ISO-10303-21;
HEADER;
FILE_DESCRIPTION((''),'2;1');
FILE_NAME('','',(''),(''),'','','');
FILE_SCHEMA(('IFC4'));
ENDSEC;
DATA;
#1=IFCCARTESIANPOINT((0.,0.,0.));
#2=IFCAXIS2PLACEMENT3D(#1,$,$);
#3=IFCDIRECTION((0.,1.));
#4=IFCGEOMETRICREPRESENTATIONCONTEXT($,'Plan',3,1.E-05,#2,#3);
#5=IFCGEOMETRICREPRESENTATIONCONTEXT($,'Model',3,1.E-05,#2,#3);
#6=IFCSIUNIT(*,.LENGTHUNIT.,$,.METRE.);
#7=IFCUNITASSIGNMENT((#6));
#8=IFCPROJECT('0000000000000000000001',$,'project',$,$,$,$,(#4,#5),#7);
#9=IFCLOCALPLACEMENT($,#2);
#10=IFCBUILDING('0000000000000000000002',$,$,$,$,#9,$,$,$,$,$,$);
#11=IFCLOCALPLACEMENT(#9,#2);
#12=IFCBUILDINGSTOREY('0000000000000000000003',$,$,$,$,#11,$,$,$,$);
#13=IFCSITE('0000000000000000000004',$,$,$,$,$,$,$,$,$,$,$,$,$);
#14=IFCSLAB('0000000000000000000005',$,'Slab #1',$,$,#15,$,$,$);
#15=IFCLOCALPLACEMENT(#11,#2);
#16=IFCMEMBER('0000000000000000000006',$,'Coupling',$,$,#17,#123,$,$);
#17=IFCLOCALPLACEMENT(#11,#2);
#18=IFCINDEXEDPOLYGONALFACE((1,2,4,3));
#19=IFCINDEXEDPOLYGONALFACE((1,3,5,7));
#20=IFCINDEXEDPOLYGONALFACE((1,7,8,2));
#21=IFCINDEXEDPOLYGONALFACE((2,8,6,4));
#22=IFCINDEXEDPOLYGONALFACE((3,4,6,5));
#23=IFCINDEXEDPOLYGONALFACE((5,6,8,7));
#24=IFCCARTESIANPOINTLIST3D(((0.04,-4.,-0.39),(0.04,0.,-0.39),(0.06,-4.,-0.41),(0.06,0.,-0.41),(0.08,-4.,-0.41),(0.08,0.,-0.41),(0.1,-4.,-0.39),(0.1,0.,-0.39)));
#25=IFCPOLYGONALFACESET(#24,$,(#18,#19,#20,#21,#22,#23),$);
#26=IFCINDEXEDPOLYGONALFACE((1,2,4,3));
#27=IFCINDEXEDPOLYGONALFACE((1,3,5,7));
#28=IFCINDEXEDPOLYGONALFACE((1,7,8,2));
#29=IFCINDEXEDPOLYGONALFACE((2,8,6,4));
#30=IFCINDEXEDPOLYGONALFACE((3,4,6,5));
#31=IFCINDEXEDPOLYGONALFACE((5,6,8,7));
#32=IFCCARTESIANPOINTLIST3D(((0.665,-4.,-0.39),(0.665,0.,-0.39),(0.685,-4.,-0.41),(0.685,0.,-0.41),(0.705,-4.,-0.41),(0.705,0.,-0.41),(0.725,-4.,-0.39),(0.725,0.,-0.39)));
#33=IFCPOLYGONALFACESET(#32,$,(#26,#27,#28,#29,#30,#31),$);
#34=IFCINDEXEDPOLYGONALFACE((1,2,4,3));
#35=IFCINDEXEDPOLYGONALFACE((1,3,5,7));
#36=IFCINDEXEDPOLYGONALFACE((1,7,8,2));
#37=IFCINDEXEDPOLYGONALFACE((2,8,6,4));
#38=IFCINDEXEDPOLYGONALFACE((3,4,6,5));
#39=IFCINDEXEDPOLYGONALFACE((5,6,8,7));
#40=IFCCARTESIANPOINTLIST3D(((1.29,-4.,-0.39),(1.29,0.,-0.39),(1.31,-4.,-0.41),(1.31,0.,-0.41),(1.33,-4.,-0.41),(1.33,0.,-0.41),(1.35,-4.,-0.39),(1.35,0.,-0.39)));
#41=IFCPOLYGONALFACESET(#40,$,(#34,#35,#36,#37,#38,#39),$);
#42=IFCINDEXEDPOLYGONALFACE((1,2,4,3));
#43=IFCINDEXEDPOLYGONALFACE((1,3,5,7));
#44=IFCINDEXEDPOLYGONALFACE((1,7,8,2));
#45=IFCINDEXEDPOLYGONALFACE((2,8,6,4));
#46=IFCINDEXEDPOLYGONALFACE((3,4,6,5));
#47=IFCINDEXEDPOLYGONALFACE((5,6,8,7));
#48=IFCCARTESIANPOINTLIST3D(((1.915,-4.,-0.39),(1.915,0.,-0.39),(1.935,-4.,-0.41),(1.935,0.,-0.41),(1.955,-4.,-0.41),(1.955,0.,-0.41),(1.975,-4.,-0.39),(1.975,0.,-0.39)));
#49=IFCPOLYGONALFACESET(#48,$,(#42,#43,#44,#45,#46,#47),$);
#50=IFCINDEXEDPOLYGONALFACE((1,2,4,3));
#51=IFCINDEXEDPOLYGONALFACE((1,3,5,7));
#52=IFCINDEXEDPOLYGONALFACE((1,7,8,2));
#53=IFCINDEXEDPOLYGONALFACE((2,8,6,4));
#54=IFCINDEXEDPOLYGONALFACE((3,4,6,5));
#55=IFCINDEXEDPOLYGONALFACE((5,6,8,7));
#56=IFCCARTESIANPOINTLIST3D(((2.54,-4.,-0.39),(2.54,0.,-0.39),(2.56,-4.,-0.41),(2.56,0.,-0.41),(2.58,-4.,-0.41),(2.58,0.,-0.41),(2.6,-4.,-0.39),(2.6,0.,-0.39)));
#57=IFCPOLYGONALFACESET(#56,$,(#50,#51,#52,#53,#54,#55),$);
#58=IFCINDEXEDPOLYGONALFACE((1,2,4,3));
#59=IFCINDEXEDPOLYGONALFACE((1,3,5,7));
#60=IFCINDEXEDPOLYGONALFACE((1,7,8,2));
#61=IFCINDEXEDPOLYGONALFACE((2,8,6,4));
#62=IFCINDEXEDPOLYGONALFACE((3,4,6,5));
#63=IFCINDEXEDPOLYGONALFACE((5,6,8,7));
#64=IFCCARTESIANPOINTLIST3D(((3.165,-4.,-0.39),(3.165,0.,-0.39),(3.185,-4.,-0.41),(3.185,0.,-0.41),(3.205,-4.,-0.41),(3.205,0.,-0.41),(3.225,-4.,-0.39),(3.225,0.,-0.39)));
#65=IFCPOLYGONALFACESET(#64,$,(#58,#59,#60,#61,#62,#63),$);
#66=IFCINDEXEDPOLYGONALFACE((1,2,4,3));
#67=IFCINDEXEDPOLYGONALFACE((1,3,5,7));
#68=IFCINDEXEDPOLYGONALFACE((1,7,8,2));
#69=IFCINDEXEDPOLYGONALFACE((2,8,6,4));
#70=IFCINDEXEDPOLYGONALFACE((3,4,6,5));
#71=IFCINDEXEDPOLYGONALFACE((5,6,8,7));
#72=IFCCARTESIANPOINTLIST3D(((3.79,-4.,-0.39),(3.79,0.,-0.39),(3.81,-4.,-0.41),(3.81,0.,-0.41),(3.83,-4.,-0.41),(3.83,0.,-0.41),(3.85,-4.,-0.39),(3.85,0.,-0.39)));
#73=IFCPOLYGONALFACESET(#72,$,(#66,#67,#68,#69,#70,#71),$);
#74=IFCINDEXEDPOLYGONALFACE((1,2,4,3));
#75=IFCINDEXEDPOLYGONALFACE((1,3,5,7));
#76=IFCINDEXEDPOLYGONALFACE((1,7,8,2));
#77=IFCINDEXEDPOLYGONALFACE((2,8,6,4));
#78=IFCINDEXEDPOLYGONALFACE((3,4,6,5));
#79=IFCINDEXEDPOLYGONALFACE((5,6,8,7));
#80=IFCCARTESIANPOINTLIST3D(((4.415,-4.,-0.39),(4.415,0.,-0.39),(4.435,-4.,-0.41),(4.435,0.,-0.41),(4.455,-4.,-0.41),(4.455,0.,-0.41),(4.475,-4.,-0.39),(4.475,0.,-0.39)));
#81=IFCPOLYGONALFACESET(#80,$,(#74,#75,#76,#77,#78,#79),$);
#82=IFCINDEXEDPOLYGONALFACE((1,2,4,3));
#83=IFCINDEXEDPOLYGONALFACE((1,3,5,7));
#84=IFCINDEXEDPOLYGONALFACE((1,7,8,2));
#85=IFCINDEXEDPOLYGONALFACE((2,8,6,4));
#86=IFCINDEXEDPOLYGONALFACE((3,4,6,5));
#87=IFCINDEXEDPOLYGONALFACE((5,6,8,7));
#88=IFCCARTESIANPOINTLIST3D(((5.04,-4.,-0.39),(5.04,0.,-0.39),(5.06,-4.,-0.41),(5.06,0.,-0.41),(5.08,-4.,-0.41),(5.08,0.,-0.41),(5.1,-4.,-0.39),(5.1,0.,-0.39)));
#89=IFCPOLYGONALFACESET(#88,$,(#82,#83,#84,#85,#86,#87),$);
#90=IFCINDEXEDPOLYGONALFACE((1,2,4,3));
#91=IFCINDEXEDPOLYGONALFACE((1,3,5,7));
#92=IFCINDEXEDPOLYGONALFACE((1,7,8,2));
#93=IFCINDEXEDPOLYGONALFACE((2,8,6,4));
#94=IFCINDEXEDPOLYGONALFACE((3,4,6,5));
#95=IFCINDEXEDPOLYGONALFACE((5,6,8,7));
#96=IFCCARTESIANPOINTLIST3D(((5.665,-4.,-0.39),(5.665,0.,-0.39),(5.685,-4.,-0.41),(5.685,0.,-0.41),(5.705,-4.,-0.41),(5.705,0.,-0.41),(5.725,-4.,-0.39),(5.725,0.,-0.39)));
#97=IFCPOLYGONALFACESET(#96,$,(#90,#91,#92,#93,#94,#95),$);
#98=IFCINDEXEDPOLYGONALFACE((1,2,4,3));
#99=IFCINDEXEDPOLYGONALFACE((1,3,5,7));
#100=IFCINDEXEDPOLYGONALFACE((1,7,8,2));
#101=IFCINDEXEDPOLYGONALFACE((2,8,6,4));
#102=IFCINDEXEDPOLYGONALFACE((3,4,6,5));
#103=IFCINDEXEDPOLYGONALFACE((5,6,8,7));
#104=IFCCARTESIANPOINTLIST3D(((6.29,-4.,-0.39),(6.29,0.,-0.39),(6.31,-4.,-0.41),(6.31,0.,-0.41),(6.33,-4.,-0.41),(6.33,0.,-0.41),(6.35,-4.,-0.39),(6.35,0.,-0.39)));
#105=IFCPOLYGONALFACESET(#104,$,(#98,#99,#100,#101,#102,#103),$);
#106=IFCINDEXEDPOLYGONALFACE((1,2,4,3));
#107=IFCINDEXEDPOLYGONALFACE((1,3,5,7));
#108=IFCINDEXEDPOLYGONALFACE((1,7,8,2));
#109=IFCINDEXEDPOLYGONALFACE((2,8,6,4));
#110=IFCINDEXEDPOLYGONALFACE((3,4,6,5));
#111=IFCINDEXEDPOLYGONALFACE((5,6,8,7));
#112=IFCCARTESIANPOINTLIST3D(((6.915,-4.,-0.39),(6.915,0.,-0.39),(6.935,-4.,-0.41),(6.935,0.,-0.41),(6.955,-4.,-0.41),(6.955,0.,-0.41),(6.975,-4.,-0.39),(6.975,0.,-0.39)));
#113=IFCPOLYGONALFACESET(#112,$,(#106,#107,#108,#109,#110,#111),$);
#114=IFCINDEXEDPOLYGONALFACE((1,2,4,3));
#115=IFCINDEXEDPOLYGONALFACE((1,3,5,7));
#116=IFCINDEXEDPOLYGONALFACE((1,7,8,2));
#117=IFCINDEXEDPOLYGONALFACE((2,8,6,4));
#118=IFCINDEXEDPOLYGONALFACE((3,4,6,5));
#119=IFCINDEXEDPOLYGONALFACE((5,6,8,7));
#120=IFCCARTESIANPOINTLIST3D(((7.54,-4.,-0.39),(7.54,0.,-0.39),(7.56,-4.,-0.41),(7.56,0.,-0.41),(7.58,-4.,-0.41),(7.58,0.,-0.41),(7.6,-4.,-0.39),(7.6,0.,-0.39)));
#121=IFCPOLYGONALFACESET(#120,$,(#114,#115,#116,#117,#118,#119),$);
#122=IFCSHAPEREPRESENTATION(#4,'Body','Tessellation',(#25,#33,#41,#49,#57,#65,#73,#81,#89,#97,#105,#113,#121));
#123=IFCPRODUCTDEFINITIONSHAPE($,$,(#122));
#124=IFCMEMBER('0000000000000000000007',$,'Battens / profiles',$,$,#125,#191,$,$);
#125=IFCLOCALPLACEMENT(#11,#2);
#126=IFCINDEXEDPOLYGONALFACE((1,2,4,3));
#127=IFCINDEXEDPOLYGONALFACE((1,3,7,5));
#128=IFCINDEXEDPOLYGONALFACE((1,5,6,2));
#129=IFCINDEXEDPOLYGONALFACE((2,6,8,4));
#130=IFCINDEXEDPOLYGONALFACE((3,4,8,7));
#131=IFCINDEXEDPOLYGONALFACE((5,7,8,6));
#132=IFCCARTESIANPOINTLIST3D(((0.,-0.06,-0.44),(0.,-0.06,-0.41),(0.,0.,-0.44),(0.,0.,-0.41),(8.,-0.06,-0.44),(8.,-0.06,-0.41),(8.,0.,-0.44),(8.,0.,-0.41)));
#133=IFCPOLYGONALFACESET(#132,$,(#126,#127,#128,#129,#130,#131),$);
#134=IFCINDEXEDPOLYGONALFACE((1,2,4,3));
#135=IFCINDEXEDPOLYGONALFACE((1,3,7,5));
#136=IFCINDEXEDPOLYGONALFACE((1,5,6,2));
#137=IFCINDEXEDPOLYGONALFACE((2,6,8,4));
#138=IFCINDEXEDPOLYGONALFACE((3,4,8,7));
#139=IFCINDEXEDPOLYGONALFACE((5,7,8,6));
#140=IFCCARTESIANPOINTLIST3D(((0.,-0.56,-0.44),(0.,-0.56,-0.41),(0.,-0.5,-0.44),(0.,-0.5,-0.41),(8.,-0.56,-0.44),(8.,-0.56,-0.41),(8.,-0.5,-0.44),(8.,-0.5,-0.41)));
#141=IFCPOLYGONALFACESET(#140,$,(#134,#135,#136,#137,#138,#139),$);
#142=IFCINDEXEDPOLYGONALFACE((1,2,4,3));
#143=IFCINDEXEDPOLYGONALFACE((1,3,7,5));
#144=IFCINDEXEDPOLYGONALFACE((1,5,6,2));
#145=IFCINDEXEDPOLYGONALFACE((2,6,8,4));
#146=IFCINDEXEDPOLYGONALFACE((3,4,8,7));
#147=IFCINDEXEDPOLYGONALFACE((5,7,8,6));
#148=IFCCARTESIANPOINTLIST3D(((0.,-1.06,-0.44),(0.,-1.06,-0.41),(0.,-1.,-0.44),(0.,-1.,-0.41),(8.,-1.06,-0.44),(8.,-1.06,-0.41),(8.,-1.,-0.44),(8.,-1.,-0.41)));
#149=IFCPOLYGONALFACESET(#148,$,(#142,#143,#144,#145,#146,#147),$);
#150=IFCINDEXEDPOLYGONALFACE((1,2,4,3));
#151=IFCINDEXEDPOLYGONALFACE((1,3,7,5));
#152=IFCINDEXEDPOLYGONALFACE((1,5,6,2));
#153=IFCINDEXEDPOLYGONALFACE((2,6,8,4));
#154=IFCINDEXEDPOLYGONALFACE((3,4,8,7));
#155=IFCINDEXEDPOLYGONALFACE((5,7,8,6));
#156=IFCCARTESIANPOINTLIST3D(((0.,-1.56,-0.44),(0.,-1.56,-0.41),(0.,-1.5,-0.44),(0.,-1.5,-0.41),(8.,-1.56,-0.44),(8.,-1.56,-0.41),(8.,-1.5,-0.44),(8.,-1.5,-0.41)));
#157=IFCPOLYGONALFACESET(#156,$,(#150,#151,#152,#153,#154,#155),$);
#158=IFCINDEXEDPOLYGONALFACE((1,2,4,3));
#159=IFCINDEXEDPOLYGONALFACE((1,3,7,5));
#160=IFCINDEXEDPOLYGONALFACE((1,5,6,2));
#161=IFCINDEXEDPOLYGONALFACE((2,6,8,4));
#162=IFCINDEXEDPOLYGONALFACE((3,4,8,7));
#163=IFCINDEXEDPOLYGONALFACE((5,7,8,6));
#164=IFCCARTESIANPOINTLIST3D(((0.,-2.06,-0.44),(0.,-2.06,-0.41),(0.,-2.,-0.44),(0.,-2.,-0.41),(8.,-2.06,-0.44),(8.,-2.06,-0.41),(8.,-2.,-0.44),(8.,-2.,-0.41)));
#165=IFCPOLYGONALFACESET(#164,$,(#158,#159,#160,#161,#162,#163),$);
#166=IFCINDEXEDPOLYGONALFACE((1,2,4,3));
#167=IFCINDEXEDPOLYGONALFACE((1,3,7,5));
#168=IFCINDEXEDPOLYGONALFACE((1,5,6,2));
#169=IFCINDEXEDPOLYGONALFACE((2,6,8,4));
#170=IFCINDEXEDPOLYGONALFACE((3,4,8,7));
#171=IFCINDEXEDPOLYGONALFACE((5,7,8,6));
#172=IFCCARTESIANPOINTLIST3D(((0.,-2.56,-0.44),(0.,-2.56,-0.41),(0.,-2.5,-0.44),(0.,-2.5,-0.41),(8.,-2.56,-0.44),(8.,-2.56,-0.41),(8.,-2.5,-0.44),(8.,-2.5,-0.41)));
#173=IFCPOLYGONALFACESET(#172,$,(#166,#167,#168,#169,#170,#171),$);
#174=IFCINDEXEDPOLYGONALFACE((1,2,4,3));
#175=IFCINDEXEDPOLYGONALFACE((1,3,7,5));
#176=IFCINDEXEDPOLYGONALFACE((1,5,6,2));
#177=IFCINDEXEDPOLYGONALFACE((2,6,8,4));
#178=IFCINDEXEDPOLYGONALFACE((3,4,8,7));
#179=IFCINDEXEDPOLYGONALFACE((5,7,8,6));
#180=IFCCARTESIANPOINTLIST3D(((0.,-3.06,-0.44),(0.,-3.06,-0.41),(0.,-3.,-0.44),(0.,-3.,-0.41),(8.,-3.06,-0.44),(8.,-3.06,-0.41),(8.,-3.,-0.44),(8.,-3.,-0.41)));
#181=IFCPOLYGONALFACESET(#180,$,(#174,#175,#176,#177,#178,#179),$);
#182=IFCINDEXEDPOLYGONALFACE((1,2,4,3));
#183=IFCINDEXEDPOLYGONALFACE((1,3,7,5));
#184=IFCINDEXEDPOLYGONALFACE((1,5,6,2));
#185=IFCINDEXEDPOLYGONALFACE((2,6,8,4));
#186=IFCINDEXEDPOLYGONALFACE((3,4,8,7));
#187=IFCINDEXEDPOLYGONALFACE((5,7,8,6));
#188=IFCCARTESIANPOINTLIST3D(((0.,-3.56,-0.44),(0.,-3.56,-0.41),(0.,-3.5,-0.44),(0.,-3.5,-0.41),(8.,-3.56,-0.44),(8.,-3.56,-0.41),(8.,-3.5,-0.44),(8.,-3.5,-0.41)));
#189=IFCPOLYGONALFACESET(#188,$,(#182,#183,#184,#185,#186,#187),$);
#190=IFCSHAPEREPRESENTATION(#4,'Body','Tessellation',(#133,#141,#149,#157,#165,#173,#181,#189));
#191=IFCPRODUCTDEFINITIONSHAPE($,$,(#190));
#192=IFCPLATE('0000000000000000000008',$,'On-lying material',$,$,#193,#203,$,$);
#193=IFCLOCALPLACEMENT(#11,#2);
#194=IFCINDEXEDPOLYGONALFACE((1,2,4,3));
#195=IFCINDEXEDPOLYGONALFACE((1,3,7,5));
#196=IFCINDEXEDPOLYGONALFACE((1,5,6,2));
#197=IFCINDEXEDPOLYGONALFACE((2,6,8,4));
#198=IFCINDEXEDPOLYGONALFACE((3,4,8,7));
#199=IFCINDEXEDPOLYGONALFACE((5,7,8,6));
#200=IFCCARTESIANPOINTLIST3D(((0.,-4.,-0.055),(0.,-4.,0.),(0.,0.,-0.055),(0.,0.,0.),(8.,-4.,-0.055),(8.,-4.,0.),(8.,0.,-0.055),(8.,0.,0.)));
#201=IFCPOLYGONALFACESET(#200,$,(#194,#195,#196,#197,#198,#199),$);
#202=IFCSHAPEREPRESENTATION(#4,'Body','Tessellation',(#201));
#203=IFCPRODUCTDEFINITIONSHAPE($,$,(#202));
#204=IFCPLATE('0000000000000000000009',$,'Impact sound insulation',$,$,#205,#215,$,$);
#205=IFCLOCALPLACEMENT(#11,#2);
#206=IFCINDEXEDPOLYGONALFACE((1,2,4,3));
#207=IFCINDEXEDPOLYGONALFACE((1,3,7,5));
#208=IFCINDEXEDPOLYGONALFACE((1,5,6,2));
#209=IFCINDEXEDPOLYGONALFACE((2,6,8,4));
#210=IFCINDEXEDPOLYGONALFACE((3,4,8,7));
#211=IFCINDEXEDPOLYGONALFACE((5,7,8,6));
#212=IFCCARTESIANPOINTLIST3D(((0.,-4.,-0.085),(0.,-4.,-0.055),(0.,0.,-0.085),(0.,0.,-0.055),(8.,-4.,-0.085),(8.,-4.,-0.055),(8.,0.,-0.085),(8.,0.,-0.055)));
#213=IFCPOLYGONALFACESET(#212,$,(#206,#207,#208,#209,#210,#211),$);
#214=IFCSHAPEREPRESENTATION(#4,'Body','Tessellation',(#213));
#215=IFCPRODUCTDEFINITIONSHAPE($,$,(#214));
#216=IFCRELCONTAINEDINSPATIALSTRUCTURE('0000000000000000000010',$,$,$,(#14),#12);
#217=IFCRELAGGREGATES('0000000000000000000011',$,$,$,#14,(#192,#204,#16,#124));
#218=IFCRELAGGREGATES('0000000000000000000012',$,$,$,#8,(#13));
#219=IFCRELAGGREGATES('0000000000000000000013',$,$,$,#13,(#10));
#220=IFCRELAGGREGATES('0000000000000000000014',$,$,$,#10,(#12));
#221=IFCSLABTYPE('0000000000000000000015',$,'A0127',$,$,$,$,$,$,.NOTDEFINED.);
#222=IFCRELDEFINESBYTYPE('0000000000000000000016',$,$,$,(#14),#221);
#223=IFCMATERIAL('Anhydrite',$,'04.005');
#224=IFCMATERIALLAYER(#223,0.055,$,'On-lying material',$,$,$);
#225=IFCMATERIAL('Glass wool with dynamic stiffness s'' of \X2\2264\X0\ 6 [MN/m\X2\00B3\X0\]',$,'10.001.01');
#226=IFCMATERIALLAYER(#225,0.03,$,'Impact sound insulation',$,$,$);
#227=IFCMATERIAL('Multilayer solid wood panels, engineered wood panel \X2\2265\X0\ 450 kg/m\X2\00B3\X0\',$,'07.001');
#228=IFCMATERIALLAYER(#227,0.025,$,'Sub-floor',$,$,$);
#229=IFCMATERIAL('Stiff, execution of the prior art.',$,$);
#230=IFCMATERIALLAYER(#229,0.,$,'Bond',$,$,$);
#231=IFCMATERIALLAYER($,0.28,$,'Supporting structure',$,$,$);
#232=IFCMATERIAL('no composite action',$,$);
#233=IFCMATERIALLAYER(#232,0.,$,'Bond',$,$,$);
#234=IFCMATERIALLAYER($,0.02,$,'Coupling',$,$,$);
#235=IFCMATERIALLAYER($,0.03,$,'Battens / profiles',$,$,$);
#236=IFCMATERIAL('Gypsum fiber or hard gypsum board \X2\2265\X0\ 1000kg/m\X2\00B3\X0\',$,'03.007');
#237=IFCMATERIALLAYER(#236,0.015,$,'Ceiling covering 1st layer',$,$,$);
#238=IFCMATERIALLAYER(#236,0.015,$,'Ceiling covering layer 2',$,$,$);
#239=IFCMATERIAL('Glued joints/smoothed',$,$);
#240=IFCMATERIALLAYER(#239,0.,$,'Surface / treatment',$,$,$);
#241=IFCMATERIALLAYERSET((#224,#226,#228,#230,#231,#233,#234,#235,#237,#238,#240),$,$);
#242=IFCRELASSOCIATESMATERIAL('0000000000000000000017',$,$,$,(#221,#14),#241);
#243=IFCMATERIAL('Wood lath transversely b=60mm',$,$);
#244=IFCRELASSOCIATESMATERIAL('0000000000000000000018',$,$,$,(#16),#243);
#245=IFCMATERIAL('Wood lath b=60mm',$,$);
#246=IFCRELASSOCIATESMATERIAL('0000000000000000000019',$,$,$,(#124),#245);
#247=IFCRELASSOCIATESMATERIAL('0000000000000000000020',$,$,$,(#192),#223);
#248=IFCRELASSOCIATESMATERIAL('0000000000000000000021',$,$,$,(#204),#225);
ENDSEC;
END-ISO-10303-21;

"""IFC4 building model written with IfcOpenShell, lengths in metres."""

from ifc_helpers import new_model, si_unit, direction, frame, frame_2d, origin, origin_with_axes, place, context, project, spatial, polyline, rectangle, outline, extrude, material, layer, layer_set, type_object, element, aggregate, save


model = new_model("IFC4")

# Units and contexts
plan_context = context("Plan", 3, precision=1e-05, world=origin(), true_north=direction((0.0, 1.0)))
model_context = context("Model", 3, precision=1e-05, world=origin(), true_north=direction((0.0, 1.0)))
ifc_project = project(units=[si_unit("LENGTHUNIT", "METRE")], contexts=[plan_context, model_context])

# Site, building, storey
site = spatial("IfcSite", under=ifc_project)
building_placement = place(None, origin())
building = spatial("IfcBuilding", under=site, at=building_placement)
storey_placement = place(building_placement, origin())
storey = spatial("IfcBuildingStorey", under=building, at=storey_placement)

# Slab, members, plates
ifc_material_1 = material(Name="Anhydrite", Category="04.005")
ifc_layer_1 = layer(ifc_material_1, 0.055, Name="On-lying material")
ifc_material_2 = material(Name="Glass wool with dynamic stiffness s' of ≤ 6 [MN/m³]", Category="10.001.01")
ifc_layer_2 = layer(ifc_material_2, 0.03, Name="Impact sound insulation")
ifc_material_3 = material(Name="Multilayer solid wood panels, engineered wood panel ≥ 450 kg/m³", Category="07.001")
ifc_layer_3 = layer(ifc_material_3, 0.025, Name="Sub-floor")
ifc_material_4 = material(Name="Stiff, execution of the prior art.")
ifc_layer_4 = layer(ifc_material_4, 0.0, Name="Bond")
ifc_layer_5 = layer(None, 0.28, Name="Supporting structure")
ifc_material_5 = material(Name="no composite action")
ifc_layer_6 = layer(ifc_material_5, 0.0, Name="Bond")
ifc_layer_7 = layer(None, 0.02, Name="Coupling")
ifc_layer_8 = layer(None, 0.03, Name="Battens / profiles")
ifc_material_6 = material(Name="Gypsum fiber or hard gypsum board ≥ 1000kg/m³", Category="03.007")
ifc_layer_9 = layer(ifc_material_6, 0.015, Name="Ceiling covering 1st layer")
ifc_layer_10 = layer(ifc_material_6, 0.015, Name="Ceiling covering layer 2")
ifc_material_7 = material(Name="Glued joints/smoothed")
ifc_layer_11 = layer(ifc_material_7, 0.0, Name="Surface / treatment")
ifc_layer_set = layer_set([ifc_layer_1, ifc_layer_2, ifc_layer_3, ifc_layer_4, ifc_layer_5, ifc_layer_6, ifc_layer_7, ifc_layer_8, ifc_layer_9, ifc_layer_10, ifc_layer_11])
slab_type = type_object("IfcSlabType", Name="A0127", PredefinedType="NOTDEFINED", material=ifc_layer_set)
slab_placement = place(None, frame((0.0, 0.0, 0.0), z_axis=(0.0, 0.0, -1.0), x_axis=(1.0, 0.0, 0.0)))
slab = element("IfcSlab", 1, at=slab_placement, inside=storey, type_object=slab_type, material=ifc_layer_set, Name="Slab #1")
ifc_material_8 = material(Name="Wood lath transversely b=60mm")
member_1_placement = place(slab_placement, origin())
member_1 = element("IfcMember", 2, at=member_1_placement, material=ifc_material_8, Name="Coupling", context=plan_context, shape_type="SweptSolid", body=[
    extrude(outline(polyline([(0.0, 0.0), (0.06, 0.0), (0.04, 0.02), (0.02, 0.02), (0.0, 0.0)])), frame((0.04, 4.0, 0.39), z_axis=(0.0, -1.0, 0.0), x_axis=(1.0, 0.0, 0.0)), (0.0, 0.0, 1.0), 4.0),
    extrude(outline(polyline([(0.0, 0.0), (0.06, 0.0), (0.04, 0.02), (0.02, 0.02), (0.0, 0.0)])), frame((0.665, 4.0, 0.39), z_axis=(0.0, -1.0, 0.0), x_axis=(1.0, 0.0, 0.0)), (0.0, 0.0, 1.0), 4.0),
    extrude(outline(polyline([(0.0, 0.0), (0.06, 0.0), (0.04, 0.02), (0.02, 0.02), (0.0, 0.0)])), frame((1.29, 4.0, 0.39), z_axis=(0.0, -1.0, 0.0), x_axis=(1.0, 0.0, 0.0)), (0.0, 0.0, 1.0), 4.0),
    extrude(outline(polyline([(0.0, 0.0), (0.06, 0.0), (0.04, 0.02), (0.02, 0.02), (0.0, 0.0)])), frame((1.915, 4.0, 0.39), z_axis=(0.0, -1.0, 0.0), x_axis=(1.0, 0.0, 0.0)), (0.0, 0.0, 1.0), 4.0),
    extrude(outline(polyline([(0.0, 0.0), (0.06, 0.0), (0.04, 0.02), (0.02, 0.02), (0.0, 0.0)])), frame((2.54, 4.0, 0.39), z_axis=(0.0, -1.0, 0.0), x_axis=(1.0, 0.0, 0.0)), (0.0, 0.0, 1.0), 4.0),
    extrude(outline(polyline([(0.0, 0.0), (0.06, 0.0), (0.04, 0.02), (0.02, 0.02), (0.0, 0.0)])), frame((3.165, 4.0, 0.39), z_axis=(0.0, -1.0, 0.0), x_axis=(1.0, 0.0, 0.0)), (0.0, 0.0, 1.0), 4.0),
    extrude(outline(polyline([(0.0, 0.0), (0.06, 0.0), (0.04, 0.02), (0.02, 0.02), (0.0, 0.0)])), frame((3.79, 4.0, 0.39), z_axis=(0.0, -1.0, 0.0), x_axis=(1.0, 0.0, 0.0)), (0.0, 0.0, 1.0), 4.0),
    extrude(outline(polyline([(0.0, 0.0), (0.06, 0.0), (0.04, 0.02), (0.02, 0.02), (0.0, 0.0)])), frame((4.415, 4.0, 0.39), z_axis=(0.0, -1.0, 0.0), x_axis=(1.0, 0.0, 0.0)), (0.0, 0.0, 1.0), 4.0),
    extrude(outline(polyline([(0.0, 0.0), (0.06, 0.0), (0.04, 0.02), (0.02, 0.02), (0.0, 0.0)])), frame((5.04, 4.0, 0.39), z_axis=(0.0, -1.0, 0.0), x_axis=(1.0, 0.0, 0.0)), (0.0, 0.0, 1.0), 4.0),
    extrude(outline(polyline([(0.0, 0.0), (0.06, 0.0), (0.04, 0.02), (0.02, 0.02), (0.0, 0.0)])), frame((5.665, 4.0, 0.39), z_axis=(0.0, -1.0, 0.0), x_axis=(1.0, 0.0, 0.0)), (0.0, 0.0, 1.0), 4.0),
    extrude(outline(polyline([(0.0, 0.0), (0.06, 0.0), (0.04, 0.02), (0.02, 0.02), (0.0, 0.0)])), frame((6.29, 4.0, 0.39), z_axis=(0.0, -1.0, 0.0), x_axis=(1.0, 0.0, 0.0)), (0.0, 0.0, 1.0), 4.0),
    extrude(outline(polyline([(0.0, 0.0), (0.06, 0.0), (0.04, 0.02), (0.02, 0.02), (0.0, 0.0)])), frame((6.915, 4.0, 0.39), z_axis=(0.0, -1.0, 0.0), x_axis=(1.0, 0.0, 0.0)), (0.0, 0.0, 1.0), 4.0),
    extrude(outline(polyline([(0.0, 0.0), (0.06, 0.0), (0.04, 0.02), (0.02, 0.02), (0.0, 0.0)])), frame((7.54, 4.0, 0.39), z_axis=(0.0, -1.0, 0.0), x_axis=(1.0, 0.0, 0.0)), (0.0, 0.0, 1.0), 4.0),
])
ifc_material_9 = material(Name="Wood lath b=60mm")
member_2_placement = place(slab_placement, origin())
member_2 = element("IfcMember", 3, at=member_2_placement, material=ifc_material_9, Name="Battens / profiles", context=plan_context, shape_type="SweptSolid", body=[
    extrude(rectangle(XDim=0.06, YDim=0.03, at=frame_2d((0.03, 0.015), x_axis=(1.0, 0.0))), frame((0.0, 0.0, 0.41), z_axis=(1.0, 0.0, 0.0), x_axis=(0.0, 1.0, 0.0)), (0.0, 0.0, 1.0), 8.0),
    extrude(rectangle(XDim=0.06, YDim=0.03, at=frame_2d((0.03, 0.015), x_axis=(1.0, 0.0))), frame((0.0, 0.5, 0.41), z_axis=(1.0, 0.0, 0.0), x_axis=(0.0, 1.0, 0.0)), (0.0, 0.0, 1.0), 8.0),
    extrude(rectangle(XDim=0.06, YDim=0.03, at=frame_2d((0.03, 0.015), x_axis=(1.0, 0.0))), frame((0.0, 1.0, 0.41), z_axis=(1.0, 0.0, 0.0), x_axis=(0.0, 1.0, 0.0)), (0.0, 0.0, 1.0), 8.0),
    extrude(rectangle(XDim=0.06, YDim=0.03, at=frame_2d((0.03, 0.015), x_axis=(1.0, 0.0))), frame((0.0, 1.5, 0.41), z_axis=(1.0, 0.0, 0.0), x_axis=(0.0, 1.0, 0.0)), (0.0, 0.0, 1.0), 8.0),
    extrude(rectangle(XDim=0.06, YDim=0.03, at=frame_2d((0.03, 0.015), x_axis=(1.0, 0.0))), frame((0.0, 2.0, 0.41), z_axis=(1.0, 0.0, 0.0), x_axis=(0.0, 1.0, 0.0)), (0.0, 0.0, 1.0), 8.0),
    extrude(rectangle(XDim=0.06, YDim=0.03, at=frame_2d((0.03, 0.015), x_axis=(1.0, 0.0))), frame((0.0, 2.5, 0.41), z_axis=(1.0, 0.0, 0.0), x_axis=(0.0, 1.0, 0.0)), (0.0, 0.0, 1.0), 8.0),
    extrude(rectangle(XDim=0.06, YDim=0.03, at=frame_2d((0.03, 0.015), x_axis=(1.0, 0.0))), frame((0.0, 3.0, 0.41), z_axis=(1.0, 0.0, 0.0), x_axis=(0.0, 1.0, 0.0)), (0.0, 0.0, 1.0), 8.0),
    extrude(rectangle(XDim=0.06, YDim=0.03, at=frame_2d((0.03, 0.015), x_axis=(1.0, 0.0))), frame((0.0, 3.5, 0.41), z_axis=(1.0, 0.0, 0.0), x_axis=(0.0, 1.0, 0.0)), (0.0, 0.0, 1.0), 8.0),
])
plate_1_placement = place(slab_placement, origin())
plate_1 = element("IfcPlate", 4, at=plate_1_placement, material=ifc_material_1, Name="On-lying material", context=plan_context, shape_type="SweptSolid", body=[
    extrude(rectangle(XDim=8.0, YDim=4.0, at=frame_2d((4.0, 2.0), x_axis=(1.0, 0.0))), origin_with_axes(), (0.0, 0.0, 1.0), 0.055),
])
plate_2_placement = place(slab_placement, origin())
plate_2 = element("IfcPlate", 5, at=plate_2_placement, material=ifc_material_2, Name="Impact sound insulation", context=plan_context, shape_type="SweptSolid", body=[
    extrude(rectangle(XDim=8.0, YDim=4.0, at=frame_2d((4.0, 2.0), x_axis=(1.0, 0.0))), frame((0.0, 0.0, 0.055), z_axis=(0.0, 0.0, 1.0), x_axis=(1.0, 0.0, 0.0)), (0.0, 0.0, 1.0), 0.03),
])
aggregate(slab, [plate_1, plate_2, member_1, member_2])

save(model, "model.ifc")
